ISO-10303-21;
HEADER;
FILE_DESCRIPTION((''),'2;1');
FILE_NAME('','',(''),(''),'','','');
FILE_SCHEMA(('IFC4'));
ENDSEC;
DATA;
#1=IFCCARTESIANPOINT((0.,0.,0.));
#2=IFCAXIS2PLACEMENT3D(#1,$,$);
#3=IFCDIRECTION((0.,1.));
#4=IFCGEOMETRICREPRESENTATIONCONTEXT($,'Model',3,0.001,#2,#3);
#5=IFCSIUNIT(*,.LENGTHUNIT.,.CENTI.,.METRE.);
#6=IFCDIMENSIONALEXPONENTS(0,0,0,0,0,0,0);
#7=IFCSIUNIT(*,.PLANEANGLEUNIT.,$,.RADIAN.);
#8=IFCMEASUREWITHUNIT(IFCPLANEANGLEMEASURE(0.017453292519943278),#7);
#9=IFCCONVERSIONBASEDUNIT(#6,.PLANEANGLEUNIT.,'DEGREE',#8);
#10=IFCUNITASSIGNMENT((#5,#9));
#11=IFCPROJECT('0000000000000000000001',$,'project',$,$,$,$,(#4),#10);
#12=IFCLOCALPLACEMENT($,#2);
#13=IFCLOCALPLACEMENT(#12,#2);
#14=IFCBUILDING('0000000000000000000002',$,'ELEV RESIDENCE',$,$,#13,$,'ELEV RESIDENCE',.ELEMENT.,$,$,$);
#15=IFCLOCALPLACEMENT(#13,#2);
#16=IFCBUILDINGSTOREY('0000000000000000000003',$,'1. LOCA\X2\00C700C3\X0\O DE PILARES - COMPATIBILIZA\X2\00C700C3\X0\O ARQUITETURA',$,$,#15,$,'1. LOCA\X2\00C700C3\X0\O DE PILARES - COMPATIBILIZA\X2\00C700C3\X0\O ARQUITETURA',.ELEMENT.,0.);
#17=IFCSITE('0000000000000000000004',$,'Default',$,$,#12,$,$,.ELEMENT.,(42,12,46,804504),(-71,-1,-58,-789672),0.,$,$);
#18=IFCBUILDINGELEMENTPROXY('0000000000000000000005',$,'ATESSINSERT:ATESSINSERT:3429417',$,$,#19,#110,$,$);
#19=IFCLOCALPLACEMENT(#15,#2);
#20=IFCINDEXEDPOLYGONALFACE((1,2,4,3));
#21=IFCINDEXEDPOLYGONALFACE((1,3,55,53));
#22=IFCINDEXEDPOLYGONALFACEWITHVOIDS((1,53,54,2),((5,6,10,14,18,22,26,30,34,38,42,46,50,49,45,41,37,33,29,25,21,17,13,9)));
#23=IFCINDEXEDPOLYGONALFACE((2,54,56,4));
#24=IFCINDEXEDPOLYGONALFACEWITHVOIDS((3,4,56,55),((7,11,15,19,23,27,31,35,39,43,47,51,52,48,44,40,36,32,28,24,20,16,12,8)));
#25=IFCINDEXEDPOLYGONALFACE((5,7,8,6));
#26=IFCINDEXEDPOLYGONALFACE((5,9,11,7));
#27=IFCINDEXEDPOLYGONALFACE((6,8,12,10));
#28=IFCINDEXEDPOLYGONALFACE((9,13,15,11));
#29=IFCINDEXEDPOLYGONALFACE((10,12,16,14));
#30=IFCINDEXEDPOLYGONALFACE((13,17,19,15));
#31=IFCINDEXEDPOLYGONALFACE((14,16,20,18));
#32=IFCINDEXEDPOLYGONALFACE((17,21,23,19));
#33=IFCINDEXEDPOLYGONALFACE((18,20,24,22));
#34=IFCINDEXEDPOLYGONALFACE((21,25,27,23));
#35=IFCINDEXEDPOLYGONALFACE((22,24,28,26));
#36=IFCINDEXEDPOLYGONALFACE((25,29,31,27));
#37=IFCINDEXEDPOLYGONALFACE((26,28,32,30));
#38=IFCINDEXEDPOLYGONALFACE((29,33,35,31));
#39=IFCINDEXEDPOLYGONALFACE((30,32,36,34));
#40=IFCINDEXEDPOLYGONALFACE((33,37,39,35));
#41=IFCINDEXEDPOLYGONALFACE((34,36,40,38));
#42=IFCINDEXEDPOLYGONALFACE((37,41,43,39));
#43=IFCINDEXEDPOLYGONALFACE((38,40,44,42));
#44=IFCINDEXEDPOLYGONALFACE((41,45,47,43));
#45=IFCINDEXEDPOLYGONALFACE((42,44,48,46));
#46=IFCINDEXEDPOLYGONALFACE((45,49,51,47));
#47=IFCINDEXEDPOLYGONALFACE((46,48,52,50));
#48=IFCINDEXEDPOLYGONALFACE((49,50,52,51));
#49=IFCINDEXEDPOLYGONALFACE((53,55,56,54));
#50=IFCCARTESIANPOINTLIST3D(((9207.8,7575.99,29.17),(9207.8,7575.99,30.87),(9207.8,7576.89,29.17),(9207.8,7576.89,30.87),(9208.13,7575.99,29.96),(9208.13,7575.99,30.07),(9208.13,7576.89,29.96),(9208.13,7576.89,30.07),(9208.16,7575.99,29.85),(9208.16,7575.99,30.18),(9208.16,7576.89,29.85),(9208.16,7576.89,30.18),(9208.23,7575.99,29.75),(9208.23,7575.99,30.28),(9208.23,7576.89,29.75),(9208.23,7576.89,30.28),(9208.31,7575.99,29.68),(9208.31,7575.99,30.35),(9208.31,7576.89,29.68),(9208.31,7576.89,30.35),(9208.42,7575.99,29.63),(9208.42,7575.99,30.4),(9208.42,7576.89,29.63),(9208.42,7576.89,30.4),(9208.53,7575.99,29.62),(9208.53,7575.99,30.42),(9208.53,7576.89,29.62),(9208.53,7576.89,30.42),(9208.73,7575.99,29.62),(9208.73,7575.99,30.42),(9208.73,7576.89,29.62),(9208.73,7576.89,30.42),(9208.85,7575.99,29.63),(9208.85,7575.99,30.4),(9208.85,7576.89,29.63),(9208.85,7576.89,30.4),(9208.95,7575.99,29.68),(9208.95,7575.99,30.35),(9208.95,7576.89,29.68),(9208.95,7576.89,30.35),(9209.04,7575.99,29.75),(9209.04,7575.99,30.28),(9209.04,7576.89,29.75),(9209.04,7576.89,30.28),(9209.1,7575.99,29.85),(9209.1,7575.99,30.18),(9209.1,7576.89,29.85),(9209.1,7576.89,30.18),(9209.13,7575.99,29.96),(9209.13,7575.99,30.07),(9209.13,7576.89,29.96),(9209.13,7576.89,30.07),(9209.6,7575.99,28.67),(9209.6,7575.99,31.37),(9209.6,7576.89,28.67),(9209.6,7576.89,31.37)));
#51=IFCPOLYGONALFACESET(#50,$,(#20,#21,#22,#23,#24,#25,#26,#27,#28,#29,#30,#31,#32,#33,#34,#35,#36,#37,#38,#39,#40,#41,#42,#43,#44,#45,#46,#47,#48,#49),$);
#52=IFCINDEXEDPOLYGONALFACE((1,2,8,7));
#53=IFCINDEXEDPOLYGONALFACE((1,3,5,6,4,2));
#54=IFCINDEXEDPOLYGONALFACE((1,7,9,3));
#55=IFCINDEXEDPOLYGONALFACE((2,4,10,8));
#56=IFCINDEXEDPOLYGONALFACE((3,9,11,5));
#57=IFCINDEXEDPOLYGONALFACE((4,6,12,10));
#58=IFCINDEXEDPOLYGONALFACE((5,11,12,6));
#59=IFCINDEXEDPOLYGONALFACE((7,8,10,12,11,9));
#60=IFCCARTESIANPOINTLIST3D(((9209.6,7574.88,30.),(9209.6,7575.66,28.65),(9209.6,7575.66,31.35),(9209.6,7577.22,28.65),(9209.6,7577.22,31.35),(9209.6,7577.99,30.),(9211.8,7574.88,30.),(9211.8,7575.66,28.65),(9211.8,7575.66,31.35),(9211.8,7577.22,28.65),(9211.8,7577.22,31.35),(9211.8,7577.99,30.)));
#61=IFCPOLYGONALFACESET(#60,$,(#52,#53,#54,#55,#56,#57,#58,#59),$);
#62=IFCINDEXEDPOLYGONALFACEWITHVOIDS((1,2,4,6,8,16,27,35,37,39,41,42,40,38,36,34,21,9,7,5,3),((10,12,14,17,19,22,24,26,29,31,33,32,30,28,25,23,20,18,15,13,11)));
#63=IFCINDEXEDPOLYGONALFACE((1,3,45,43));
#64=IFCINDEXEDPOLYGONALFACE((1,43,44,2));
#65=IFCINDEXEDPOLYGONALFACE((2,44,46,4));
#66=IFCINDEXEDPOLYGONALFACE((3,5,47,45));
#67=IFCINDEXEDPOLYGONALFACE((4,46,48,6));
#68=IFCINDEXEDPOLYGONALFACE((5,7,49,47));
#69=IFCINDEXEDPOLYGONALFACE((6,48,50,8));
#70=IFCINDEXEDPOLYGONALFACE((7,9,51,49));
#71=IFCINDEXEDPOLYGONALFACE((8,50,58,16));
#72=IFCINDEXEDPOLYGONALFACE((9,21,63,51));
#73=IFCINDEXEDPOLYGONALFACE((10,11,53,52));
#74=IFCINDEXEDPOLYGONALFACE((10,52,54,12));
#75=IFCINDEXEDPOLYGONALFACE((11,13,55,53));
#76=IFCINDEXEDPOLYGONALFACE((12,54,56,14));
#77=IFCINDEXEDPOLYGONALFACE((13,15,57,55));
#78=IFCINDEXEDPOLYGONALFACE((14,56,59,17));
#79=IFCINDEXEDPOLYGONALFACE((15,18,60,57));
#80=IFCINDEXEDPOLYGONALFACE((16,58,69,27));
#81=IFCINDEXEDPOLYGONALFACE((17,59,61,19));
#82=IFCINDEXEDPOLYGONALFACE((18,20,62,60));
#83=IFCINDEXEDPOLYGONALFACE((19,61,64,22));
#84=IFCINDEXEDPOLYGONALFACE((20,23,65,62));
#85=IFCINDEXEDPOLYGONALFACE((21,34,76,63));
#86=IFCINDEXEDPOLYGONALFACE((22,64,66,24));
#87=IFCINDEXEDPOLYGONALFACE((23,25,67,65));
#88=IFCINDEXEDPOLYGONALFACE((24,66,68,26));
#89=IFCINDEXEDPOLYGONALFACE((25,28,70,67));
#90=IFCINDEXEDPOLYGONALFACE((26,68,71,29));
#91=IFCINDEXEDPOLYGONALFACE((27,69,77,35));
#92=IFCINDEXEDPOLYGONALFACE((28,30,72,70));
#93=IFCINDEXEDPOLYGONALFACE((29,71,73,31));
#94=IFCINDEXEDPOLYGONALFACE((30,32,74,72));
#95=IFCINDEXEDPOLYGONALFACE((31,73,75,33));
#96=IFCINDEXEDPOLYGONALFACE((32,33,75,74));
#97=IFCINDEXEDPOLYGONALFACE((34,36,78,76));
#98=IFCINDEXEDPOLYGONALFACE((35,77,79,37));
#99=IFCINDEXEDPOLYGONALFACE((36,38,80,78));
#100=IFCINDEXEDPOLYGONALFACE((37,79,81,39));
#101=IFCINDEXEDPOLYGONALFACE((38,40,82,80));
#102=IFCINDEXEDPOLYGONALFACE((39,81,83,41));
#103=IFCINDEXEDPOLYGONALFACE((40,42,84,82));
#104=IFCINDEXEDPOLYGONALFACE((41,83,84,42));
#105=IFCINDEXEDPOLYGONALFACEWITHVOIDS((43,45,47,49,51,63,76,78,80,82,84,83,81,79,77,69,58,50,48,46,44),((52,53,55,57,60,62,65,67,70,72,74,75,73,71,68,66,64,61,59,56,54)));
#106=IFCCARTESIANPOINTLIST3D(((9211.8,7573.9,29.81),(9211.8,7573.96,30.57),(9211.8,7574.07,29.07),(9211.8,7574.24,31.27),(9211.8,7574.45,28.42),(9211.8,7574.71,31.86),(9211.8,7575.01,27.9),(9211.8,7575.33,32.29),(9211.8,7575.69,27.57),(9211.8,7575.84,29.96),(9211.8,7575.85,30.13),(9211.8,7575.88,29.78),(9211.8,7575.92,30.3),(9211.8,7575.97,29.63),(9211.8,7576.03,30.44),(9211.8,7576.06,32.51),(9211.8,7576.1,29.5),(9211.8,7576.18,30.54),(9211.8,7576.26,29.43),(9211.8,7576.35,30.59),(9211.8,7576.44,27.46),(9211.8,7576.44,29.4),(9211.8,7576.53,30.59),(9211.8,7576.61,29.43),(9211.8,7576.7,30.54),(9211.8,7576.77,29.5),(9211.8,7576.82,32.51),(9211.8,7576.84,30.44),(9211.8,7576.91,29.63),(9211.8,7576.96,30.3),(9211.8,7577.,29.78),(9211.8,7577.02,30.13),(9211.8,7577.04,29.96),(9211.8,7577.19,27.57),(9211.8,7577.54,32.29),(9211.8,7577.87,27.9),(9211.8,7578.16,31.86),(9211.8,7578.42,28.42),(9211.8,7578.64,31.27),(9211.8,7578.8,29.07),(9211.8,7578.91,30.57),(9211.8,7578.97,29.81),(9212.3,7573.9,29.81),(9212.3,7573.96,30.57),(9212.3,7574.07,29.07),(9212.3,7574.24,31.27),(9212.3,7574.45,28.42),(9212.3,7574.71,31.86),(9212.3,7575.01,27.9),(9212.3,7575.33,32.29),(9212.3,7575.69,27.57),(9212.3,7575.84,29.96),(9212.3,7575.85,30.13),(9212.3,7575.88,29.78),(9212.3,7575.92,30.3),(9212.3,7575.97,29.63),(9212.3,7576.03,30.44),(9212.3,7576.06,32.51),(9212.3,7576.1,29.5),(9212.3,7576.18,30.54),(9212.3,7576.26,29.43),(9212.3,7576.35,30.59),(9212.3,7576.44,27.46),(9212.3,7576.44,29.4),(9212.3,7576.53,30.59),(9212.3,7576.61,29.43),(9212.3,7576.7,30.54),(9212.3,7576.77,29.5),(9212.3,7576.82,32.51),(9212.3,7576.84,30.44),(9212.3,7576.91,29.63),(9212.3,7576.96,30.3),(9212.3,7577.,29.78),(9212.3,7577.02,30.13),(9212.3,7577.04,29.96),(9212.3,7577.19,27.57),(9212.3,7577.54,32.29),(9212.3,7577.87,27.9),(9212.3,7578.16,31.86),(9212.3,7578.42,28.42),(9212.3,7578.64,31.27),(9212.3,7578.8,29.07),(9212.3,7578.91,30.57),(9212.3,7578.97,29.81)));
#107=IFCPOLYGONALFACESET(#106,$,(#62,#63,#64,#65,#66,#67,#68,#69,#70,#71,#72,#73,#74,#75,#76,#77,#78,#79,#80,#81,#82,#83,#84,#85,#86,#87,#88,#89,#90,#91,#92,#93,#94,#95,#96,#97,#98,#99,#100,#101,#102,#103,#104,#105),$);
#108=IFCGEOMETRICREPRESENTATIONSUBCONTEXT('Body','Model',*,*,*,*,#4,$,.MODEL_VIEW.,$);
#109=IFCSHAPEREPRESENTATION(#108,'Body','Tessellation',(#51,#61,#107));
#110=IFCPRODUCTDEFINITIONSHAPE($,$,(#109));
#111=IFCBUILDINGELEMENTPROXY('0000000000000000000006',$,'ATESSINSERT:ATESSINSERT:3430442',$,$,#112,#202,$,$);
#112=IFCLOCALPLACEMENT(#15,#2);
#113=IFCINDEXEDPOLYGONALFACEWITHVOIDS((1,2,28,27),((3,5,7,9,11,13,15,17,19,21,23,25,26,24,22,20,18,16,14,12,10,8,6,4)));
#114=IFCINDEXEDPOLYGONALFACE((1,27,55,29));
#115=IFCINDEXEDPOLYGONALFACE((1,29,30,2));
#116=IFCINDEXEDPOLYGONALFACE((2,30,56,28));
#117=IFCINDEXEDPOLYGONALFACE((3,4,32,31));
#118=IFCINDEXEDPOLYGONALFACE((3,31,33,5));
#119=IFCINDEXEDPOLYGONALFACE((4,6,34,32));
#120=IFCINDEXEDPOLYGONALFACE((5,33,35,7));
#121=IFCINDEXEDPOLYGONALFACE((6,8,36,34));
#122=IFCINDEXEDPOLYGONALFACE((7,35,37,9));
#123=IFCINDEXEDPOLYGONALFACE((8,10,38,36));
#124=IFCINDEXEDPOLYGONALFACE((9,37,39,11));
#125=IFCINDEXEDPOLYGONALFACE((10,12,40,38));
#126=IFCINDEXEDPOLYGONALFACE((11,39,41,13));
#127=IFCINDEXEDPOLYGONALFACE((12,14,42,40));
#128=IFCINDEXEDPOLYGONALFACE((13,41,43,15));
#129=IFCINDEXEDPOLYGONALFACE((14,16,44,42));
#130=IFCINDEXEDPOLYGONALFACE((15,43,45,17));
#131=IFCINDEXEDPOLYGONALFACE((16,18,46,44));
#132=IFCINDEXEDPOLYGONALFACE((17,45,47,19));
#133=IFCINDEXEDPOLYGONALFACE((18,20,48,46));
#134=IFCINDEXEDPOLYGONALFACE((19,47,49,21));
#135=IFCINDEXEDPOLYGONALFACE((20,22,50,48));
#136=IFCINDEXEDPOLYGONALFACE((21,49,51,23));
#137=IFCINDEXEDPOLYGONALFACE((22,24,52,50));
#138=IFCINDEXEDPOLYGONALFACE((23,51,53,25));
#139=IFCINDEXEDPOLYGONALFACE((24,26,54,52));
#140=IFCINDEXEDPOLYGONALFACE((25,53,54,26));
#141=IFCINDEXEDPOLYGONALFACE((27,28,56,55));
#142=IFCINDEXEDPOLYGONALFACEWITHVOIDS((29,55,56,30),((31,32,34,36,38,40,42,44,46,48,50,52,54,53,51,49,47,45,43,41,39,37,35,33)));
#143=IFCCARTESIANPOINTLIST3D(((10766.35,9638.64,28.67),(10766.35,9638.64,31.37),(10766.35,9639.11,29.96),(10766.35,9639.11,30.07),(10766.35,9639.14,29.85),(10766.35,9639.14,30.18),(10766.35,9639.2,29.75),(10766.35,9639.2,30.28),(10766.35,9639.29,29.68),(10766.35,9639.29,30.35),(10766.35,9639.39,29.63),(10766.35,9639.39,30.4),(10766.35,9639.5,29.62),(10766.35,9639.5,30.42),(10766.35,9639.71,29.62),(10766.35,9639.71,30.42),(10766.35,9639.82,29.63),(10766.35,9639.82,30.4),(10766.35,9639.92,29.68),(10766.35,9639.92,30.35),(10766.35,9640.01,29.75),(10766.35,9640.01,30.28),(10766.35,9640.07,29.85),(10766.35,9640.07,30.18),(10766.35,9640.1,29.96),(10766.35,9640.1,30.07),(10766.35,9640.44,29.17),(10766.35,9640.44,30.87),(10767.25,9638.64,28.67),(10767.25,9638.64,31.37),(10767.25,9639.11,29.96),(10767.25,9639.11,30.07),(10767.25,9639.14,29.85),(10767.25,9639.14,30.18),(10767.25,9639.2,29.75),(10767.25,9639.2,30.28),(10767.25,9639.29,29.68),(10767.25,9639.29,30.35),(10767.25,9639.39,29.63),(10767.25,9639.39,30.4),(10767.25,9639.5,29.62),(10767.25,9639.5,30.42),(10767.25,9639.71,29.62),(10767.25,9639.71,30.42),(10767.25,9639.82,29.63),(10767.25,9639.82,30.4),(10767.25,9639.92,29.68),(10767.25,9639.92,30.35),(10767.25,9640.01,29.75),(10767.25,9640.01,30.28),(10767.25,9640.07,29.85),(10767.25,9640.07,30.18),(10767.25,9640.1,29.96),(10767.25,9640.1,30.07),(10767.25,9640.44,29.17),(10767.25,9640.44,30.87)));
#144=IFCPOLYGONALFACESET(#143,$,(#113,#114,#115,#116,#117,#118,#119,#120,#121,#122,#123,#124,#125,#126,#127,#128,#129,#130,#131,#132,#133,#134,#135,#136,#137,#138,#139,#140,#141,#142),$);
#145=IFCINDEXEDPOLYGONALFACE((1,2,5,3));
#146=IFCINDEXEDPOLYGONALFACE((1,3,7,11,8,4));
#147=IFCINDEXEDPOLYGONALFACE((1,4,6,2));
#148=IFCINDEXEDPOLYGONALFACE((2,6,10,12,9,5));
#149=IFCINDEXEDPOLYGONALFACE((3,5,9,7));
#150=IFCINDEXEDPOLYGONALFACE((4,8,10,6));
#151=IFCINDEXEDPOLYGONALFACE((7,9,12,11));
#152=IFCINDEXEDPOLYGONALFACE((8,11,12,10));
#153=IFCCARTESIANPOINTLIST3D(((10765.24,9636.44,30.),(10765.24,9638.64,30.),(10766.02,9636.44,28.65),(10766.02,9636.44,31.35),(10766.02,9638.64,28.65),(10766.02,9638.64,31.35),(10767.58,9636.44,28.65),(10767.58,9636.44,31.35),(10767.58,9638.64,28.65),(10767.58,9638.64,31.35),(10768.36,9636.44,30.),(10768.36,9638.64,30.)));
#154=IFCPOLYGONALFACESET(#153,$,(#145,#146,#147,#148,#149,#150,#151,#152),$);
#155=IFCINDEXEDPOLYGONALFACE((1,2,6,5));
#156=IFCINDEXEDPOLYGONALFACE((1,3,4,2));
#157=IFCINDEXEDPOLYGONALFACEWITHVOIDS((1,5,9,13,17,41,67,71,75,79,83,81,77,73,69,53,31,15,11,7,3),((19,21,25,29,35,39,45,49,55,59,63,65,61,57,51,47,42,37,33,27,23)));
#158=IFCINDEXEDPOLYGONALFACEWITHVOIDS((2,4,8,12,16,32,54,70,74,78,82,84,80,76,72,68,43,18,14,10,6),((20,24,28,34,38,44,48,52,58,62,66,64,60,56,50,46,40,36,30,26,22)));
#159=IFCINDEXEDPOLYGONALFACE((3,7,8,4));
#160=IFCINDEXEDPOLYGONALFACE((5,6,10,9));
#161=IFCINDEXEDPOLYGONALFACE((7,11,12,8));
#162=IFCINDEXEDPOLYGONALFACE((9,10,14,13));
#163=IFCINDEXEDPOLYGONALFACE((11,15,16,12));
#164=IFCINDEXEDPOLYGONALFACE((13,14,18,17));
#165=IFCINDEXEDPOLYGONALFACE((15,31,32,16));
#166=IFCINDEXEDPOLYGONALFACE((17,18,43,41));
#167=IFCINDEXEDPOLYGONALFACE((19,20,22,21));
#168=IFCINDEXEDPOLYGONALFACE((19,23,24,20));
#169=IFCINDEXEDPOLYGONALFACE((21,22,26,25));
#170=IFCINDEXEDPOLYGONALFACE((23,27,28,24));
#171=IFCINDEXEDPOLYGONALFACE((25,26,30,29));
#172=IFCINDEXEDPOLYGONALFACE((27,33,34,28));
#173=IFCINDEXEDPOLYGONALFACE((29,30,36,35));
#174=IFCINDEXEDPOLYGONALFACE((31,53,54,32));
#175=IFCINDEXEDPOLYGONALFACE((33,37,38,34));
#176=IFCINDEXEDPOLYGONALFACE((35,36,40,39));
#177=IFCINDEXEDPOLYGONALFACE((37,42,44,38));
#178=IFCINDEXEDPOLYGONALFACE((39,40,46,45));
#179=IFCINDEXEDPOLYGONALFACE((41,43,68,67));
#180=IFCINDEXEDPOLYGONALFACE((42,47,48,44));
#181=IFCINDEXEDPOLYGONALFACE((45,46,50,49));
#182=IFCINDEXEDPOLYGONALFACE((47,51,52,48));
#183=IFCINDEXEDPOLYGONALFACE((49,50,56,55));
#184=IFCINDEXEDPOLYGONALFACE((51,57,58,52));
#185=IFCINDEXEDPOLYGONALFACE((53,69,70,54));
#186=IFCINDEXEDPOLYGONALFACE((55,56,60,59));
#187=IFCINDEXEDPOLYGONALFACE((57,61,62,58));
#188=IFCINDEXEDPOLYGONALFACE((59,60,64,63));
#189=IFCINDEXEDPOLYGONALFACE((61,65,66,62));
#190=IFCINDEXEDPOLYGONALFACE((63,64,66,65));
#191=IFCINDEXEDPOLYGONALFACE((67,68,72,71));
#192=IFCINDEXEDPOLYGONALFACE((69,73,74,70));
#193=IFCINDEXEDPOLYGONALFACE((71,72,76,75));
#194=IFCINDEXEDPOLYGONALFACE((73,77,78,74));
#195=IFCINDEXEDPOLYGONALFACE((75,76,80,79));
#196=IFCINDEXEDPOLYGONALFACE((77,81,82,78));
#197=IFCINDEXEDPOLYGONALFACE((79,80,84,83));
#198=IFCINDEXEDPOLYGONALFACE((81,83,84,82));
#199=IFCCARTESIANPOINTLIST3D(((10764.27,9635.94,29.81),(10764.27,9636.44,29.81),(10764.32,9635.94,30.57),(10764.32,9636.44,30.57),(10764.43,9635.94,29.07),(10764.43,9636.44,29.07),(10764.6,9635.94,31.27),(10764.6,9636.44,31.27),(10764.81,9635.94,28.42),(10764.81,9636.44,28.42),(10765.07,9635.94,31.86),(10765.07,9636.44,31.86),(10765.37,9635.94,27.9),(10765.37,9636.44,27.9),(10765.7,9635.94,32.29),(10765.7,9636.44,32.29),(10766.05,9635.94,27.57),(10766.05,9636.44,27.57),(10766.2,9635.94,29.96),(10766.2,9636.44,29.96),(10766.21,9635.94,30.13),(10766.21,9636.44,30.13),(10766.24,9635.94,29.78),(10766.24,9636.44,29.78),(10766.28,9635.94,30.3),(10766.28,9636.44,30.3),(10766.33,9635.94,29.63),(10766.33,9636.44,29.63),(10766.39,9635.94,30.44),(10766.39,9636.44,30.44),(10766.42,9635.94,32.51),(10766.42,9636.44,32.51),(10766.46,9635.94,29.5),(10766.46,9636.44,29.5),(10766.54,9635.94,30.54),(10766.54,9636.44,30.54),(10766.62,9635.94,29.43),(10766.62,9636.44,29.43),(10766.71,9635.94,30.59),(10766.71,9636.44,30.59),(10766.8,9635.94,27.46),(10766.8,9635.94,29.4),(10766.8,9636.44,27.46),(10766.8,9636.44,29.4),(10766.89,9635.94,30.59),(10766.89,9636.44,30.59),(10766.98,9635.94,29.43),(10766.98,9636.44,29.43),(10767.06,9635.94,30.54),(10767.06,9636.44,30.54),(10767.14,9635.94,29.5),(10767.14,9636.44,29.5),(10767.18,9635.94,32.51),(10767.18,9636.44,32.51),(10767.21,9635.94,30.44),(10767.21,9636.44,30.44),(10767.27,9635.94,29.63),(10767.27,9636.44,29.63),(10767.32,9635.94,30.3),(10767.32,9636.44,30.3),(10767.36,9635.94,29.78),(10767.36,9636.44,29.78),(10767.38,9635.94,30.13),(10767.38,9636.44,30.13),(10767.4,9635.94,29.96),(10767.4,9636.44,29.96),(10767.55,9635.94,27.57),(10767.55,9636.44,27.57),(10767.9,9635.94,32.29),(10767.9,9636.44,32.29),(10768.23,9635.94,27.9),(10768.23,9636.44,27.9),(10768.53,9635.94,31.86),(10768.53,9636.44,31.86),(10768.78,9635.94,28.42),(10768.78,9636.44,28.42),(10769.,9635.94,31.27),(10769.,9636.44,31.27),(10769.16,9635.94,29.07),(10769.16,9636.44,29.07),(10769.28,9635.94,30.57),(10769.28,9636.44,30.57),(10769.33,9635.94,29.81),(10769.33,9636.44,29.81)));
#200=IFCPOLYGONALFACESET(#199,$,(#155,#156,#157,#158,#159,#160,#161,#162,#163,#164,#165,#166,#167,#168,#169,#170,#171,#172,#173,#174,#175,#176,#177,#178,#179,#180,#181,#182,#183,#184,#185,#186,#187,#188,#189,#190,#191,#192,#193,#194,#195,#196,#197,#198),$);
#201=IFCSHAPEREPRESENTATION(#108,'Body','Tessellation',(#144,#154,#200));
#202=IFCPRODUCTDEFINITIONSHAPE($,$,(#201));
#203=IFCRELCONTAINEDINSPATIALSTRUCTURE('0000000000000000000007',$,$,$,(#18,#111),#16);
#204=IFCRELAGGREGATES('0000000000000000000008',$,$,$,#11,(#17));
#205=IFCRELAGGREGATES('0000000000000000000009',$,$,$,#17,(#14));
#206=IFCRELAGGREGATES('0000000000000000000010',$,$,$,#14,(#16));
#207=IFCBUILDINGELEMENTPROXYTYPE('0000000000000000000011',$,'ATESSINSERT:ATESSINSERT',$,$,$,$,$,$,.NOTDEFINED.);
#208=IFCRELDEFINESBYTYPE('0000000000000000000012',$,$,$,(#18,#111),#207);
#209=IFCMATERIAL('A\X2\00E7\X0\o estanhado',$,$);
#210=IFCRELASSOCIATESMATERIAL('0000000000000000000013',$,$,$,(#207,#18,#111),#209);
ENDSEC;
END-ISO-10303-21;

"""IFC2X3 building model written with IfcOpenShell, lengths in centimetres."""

from ifc_helpers import new_model, entity, si_unit, converted_unit, direction, frame, frame_2d, origin, place, context, subcontext, project, spatial, polyline, circle_curve, parameter, trimmed, segment, composite_curve, hollow_circle, outline, extrude, source, transform, mapped, material, type_object, type_shapes, element, save


model = new_model("IFC2X3")

# Units and contexts
model_context = context("Model", 3, precision=0.001, world=origin(), true_north=direction((0.0, 1.0)))
body_context = subcontext(model_context, "Body", "Model", "MODEL_VIEW")
ifc_project = project(units=[si_unit("LENGTHUNIT", "METRE", prefix="CENTI"), converted_unit("PLANEANGLEUNIT", "DEGREE", entity("IfcPlaneAngleMeasure", 0.017453292519943278), si_unit("PLANEANGLEUNIT", "RADIAN"), dimensions=[0, 0, 0, 0, 0, 0, 0])], contexts=[model_context])

# Site, building, storey
site_placement = place(None, origin())
site = spatial("IfcSite", under=ifc_project, at=site_placement, Name="Default", CompositionType="ELEMENT", RefLatitude=(42, 12, 46, 804504), RefLongitude=(-71, -1, -58, -789672), RefElevation=0.0)
building_placement = place(site_placement, origin())
building = spatial("IfcBuilding", under=site, at=building_placement, Name="ELEV RESIDENCE", LongName="ELEV RESIDENCE", CompositionType="ELEMENT")
storey_placement = place(building_placement, origin())
storey = spatial("IfcBuildingStorey", under=building, at=storey_placement, Name="1. LOCAÇÃO DE PILARES - COMPATIBILIZAÇÃO ARQUITETURA", LongName="1. LOCAÇÃO DE PILARES - COMPATIBILIZAÇÃO ARQUITETURA", CompositionType="ELEMENT", Elevation=0.0)

# Building element proxies
ifc_material_1 = material(Name="Aço estanhado")
building_element_proxy_type_1 = type_object("IfcBuildingElementProxyType", Name="ATESSINSERT:ATESSINSERT", PredefinedType="NOTDEFINED", material=ifc_material_1)
shared_shape_1 = source(origin(), body_context, "Body", "SweptSolid", [
    extrude(outline(polyline([(-1.35, -0.9), (1.35, -0.9), (0.85, 0.9), (-0.85, 0.9), (-1.35, -0.9)]), holes=[composite_curve([segment(trimmed(circle_curve(frame_2d((0.0, 0.17), x_axis=(1.0, 0.0)), 0.4), [parameter(0.0)], [parameter(180.0)], True, "PARAMETER"), False, "CONTINUOUS"), segment(polyline([(0.4, 0.17), (0.4, -0.03)]), True, "CONTINUOUS"), segment(trimmed(circle_curve(frame_2d((0.0, -0.03), x_axis=(1.0, 0.0)), 0.4), [parameter(180.0)], [parameter(0.0)], True, "PARAMETER"), False, "CONTINUOUS"), segment(polyline([(-0.4, -0.03), (-0.4, 0.17)]), True, "CONTINUOUS")], self_intersect=False)]), frame((-1.4, -0.45, 30.02), z_axis=(0.0, 1.0, 0.0), x_axis=(0.0, 0.0, 1.0)), (0.0, 0.0, 1.0), 0.9),
    extrude(outline(polyline([(-0.78, -1.35), (0.78, -1.35), (1.56, 0.0), (0.78, 1.35), (-0.78, 1.35), (-1.56, 0.0), (-0.78, -1.35)])), frame((-4.5, 0.0, 30.0), z_axis=(1.0, 0.0, 0.0), x_axis=(0.0, 0.5, 0.866025)), (0.0, 0.0, 1.0), 2.2),
    extrude(hollow_circle(Radius=2.54, WallThickness=1.94, at=frame_2d((0.0, 0.0), x_axis=(1.0, 0.0))), frame((-5.0, 0.0, 30.0), z_axis=(1.0, 0.0, 0.0), x_axis=(0.0, 0.0, -1.0)), (0.0, 0.0, 1.0), 0.5),
])
type_shapes(building_element_proxy_type_1, [shared_shape_1])
for number, where, z_axis, x_axis, name in (
    (1, (9207.3, 7576.44, 0.0), (0.0, 0.0, 1.0), (-1.0, 0.0, 0.0), "ATESSINSERT:ATESSINSERT:3429417"),
    (2, (10766.8, 9640.94, 0.0), (0.0, 0.0, 1.0), (0.0, 1.0, 0.0), "ATESSINSERT:ATESSINSERT:3430442"),
):
    element("IfcBuildingElementProxy", number, at=place(storey_placement, frame(where, z_axis=z_axis, x_axis=x_axis)), inside=storey, type_object=building_element_proxy_type_1, material=ifc_material_1, Name=name, context=body_context, shape_type="MappedRepresentation", body=[
        mapped(shared_shape_1, transform((0.0, 0.0, 0.0), scale=1.0)),
    ])

save(model, "model.ifc")
